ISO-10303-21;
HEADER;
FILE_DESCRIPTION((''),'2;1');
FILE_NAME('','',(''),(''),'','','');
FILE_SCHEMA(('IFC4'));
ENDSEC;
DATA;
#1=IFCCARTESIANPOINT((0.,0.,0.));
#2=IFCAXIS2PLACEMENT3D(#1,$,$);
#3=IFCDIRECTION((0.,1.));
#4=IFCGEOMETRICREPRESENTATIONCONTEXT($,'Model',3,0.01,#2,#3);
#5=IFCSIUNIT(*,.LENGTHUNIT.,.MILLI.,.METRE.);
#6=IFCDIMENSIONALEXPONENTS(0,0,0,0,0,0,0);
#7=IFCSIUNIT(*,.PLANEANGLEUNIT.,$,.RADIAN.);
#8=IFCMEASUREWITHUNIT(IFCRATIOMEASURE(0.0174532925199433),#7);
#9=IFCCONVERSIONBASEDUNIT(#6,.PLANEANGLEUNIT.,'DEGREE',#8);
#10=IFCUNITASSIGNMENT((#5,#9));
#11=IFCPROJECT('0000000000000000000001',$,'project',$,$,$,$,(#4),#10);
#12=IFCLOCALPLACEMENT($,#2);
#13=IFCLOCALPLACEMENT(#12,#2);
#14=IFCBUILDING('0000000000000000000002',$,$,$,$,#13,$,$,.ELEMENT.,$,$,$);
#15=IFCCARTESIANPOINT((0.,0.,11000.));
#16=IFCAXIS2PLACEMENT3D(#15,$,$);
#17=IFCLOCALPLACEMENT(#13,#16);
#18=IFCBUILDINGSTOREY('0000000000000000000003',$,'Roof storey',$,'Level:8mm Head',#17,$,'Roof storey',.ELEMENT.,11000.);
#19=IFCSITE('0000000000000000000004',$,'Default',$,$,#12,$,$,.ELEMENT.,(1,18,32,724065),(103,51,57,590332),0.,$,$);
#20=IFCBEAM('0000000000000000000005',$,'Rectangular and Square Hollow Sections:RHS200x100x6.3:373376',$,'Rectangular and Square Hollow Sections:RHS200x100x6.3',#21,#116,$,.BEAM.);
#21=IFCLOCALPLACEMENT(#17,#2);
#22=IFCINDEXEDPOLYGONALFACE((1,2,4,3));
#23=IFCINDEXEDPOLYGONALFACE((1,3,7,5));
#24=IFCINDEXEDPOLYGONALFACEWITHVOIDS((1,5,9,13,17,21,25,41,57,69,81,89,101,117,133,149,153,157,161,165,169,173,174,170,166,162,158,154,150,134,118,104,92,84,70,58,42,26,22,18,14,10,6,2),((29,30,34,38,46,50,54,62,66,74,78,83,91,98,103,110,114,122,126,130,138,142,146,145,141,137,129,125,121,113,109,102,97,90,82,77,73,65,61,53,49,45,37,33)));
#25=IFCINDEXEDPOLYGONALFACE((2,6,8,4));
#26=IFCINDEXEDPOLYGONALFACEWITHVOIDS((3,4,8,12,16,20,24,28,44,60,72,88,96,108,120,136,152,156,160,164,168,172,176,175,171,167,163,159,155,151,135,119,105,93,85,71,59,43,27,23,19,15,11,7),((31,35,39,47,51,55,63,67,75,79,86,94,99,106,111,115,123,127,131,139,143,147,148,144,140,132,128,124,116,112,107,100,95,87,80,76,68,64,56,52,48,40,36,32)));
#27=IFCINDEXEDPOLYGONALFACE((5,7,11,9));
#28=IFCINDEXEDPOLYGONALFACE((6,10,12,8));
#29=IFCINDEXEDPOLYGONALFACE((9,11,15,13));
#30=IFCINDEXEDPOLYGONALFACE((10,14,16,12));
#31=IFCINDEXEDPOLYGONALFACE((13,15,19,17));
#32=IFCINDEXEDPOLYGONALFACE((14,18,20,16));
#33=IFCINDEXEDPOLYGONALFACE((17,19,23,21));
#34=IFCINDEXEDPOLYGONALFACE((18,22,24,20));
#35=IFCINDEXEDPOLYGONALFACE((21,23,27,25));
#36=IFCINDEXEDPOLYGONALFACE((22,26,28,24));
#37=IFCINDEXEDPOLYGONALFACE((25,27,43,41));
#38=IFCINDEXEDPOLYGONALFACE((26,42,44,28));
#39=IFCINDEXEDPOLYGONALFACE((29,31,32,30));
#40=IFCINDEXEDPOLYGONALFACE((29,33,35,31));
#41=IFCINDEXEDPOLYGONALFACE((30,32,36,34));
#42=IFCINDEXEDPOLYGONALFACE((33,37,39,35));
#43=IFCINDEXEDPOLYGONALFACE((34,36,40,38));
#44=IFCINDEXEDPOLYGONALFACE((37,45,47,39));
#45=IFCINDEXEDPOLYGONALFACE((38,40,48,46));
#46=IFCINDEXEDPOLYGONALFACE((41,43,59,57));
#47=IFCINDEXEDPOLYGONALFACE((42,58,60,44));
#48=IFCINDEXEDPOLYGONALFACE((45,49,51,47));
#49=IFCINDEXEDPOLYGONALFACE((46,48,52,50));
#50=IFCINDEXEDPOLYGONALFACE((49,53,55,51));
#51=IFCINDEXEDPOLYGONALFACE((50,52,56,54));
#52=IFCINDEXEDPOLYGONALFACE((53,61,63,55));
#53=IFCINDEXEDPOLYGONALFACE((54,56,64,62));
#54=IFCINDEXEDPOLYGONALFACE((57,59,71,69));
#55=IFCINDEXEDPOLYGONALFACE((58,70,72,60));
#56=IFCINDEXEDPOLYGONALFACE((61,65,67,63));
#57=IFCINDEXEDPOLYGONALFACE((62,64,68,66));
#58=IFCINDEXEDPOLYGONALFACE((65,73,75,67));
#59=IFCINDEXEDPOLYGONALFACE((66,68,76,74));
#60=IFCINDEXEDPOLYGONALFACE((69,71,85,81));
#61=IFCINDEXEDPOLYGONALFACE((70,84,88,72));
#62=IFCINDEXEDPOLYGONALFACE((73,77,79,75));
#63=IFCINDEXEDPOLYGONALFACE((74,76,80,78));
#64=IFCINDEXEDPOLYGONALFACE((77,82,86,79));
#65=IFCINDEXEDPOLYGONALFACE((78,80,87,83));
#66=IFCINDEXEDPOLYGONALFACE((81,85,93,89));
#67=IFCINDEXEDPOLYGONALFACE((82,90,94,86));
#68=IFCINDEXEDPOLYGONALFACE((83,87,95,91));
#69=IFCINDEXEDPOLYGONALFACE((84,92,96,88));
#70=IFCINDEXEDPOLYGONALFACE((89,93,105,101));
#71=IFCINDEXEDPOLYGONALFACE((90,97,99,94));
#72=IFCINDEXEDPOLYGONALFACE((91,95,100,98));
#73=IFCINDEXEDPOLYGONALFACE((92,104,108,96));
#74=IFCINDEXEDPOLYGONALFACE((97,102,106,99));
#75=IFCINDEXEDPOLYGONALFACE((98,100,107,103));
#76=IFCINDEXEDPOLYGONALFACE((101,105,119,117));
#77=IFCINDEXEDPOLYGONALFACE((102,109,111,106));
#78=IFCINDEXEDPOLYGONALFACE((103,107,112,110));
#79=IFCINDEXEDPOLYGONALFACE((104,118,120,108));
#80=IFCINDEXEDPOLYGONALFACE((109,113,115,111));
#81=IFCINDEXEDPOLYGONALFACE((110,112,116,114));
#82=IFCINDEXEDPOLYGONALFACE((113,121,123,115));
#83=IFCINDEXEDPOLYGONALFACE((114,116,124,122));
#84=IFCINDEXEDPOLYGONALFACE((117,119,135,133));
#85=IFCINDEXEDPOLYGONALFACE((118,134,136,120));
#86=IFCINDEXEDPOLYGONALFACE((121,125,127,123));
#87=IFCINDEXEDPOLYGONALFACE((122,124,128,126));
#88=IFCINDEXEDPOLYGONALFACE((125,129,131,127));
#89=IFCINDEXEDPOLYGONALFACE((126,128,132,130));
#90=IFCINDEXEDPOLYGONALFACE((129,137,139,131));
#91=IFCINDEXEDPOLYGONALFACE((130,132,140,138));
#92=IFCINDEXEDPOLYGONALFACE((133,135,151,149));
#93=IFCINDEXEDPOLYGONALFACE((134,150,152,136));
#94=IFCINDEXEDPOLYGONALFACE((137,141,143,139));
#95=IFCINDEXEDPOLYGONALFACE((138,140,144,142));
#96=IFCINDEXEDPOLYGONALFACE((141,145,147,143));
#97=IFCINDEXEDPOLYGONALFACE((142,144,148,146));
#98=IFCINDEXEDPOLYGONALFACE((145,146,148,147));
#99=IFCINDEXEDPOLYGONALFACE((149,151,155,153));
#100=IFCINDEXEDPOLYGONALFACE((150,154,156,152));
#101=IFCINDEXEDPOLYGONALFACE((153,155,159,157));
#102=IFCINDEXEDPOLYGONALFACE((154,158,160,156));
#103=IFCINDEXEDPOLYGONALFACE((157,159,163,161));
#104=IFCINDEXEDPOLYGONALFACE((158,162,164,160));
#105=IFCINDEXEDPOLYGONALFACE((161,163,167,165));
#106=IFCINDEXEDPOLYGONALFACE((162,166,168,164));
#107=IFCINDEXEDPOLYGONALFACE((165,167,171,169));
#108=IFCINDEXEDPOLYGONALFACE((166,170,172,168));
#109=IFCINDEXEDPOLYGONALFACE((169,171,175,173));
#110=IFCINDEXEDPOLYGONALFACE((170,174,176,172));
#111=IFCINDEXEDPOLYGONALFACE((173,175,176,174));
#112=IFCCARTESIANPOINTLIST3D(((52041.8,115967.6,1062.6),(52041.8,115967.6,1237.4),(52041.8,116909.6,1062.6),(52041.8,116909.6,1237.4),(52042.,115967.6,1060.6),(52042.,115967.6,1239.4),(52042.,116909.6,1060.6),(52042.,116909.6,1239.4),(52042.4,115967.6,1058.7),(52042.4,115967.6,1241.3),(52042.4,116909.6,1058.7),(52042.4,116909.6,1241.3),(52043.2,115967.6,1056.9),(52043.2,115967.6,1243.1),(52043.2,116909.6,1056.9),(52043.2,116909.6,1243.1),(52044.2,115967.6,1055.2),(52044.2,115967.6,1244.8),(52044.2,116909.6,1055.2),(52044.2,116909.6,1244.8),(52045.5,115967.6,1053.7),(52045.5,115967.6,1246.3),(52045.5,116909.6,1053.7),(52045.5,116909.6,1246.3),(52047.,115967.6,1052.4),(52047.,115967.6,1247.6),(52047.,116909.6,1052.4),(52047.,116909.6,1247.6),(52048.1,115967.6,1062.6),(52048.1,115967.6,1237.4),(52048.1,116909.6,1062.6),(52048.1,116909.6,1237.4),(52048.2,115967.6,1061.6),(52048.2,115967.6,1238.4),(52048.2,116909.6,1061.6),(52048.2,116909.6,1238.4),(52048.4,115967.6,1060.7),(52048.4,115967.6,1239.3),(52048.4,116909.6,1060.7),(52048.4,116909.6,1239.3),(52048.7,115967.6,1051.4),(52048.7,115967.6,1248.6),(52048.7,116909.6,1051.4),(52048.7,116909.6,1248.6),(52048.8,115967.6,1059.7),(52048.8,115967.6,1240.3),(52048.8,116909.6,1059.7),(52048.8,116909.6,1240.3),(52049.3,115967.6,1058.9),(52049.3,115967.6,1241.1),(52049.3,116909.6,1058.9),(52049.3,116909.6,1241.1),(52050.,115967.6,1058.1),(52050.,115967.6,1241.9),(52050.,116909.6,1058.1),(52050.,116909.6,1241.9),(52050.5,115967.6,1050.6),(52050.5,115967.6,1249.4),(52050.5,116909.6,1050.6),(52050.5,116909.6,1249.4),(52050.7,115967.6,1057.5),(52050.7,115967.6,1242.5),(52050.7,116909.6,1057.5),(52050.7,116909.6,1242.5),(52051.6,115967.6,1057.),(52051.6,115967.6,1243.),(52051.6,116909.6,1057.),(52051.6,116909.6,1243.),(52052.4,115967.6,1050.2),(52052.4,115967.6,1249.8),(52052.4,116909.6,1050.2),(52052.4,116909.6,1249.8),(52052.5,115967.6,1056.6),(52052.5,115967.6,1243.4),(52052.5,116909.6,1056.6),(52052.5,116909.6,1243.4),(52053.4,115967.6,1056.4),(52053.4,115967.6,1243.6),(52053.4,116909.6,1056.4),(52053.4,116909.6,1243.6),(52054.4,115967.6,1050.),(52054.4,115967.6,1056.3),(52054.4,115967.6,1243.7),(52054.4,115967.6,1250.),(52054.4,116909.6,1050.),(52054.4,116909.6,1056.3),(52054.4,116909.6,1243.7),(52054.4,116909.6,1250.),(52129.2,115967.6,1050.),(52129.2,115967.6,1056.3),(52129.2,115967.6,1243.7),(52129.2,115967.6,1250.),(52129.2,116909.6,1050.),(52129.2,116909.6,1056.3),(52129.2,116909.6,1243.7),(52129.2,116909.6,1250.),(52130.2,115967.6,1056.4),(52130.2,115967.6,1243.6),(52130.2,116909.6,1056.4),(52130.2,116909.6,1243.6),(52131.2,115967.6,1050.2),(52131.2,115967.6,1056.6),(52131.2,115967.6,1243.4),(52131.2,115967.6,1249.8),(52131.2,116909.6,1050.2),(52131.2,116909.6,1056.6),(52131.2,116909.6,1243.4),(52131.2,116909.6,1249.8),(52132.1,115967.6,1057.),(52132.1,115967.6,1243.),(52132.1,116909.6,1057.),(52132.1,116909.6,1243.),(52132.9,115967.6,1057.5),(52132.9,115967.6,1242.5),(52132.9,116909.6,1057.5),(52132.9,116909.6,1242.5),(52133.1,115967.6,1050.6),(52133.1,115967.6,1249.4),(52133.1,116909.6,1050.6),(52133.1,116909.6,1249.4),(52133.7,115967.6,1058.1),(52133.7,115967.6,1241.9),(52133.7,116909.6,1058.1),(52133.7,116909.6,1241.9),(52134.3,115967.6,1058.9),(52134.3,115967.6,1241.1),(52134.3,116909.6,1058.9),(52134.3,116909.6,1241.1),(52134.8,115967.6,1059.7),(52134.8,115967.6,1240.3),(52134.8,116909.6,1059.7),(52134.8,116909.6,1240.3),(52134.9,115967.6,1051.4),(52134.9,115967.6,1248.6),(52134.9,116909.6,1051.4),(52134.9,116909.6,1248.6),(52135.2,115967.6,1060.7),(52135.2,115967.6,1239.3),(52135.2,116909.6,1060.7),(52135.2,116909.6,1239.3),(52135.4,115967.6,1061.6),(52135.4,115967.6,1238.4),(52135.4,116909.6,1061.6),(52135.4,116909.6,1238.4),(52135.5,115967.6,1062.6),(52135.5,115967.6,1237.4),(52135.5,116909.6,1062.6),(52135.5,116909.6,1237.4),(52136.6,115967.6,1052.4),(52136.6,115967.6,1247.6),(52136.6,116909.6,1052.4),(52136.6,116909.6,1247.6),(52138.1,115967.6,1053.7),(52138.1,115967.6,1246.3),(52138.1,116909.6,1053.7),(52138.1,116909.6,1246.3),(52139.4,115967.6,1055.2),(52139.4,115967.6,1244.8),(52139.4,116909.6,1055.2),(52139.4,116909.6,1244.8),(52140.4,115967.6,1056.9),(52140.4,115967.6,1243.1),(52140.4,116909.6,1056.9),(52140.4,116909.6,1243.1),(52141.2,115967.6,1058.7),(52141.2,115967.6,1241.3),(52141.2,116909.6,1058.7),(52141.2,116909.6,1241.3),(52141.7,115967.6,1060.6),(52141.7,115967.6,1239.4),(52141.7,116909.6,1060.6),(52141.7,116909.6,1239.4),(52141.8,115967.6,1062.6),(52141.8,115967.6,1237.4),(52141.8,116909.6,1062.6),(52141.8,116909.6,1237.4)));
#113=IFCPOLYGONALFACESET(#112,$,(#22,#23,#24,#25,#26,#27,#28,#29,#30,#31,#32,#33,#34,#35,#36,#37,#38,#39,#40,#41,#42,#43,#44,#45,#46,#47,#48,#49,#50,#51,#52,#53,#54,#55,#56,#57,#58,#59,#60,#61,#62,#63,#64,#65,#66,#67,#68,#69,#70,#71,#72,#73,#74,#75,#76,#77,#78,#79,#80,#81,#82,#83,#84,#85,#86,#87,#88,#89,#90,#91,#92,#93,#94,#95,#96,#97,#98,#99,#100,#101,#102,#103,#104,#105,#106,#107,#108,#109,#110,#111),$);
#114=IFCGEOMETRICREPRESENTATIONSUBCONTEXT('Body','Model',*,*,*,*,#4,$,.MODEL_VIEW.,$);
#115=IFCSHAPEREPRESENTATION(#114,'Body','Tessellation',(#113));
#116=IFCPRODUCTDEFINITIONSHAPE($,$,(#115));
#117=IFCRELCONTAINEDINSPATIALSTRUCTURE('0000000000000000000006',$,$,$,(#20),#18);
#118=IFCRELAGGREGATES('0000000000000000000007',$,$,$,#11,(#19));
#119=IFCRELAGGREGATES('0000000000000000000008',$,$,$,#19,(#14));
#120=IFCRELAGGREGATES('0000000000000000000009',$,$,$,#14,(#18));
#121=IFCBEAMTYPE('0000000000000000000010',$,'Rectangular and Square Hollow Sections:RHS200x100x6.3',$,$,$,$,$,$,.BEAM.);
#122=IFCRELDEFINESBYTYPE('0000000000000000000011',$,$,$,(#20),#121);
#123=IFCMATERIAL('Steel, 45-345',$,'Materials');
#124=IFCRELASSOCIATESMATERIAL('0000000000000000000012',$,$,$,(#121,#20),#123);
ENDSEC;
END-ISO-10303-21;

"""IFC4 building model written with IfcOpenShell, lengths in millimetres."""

from ifc_helpers import new_model, entity, si_unit, converted_unit, direction, frame, origin, place, context, subcontext, project, spatial, indexed_curve, outline, extrude, source, transform, mapped, material, type_object, type_shapes, element, save


model = new_model("IFC4")

# Units and contexts
model_context = context("Model", 3, precision=0.01, world=origin(), true_north=direction((0.0, 1.0)))
body_context = subcontext(model_context, "Body", "Model", "MODEL_VIEW")
ifc_project = project(units=[si_unit("LENGTHUNIT", "METRE", prefix="MILLI"), converted_unit("PLANEANGLEUNIT", "DEGREE", entity("IfcRatioMeasure", 0.0174532925199433), si_unit("PLANEANGLEUNIT", "RADIAN"), dimensions=[0, 0, 0, 0, 0, 0, 0])], contexts=[model_context])

# Site, building, storey
site_placement = place(None, origin())
site = spatial("IfcSite", under=ifc_project, at=site_placement, Name="Default", CompositionType="ELEMENT", RefLatitude=(1, 18, 32, 724065), RefLongitude=(103, 51, 57, 590332), RefElevation=0.0)
building_placement = place(site_placement, origin())
building = spatial("IfcBuilding", under=site, at=building_placement, CompositionType="ELEMENT")
storey_placement = place(building_placement, frame((0.0, 0.0, 11000.0)))
storey = spatial("IfcBuildingStorey", under=building, at=storey_placement, Name="Roof storey", ObjectType="Level:8mm Head", LongName="Roof storey", CompositionType="ELEMENT", Elevation=11000.0)

# Shared definitions
ifc_material = material(Name="Steel, 45-345", Category="Materials")

# Beam
beam_type_1 = type_object("IfcBeamType", Name="Rectangular and Square Hollow Sections:RHS200x100x6.3", PredefinedType="BEAM", material=ifc_material)
shared_shape_1 = source(origin(), body_context, "Body", "SweptSolid", [
    extrude(outline(indexed_curve([(-50.0, -87.4), (-49.8, -89.4), (-49.4, -91.3), (-48.6, -93.1), (-47.6, -94.8), (-46.3, -96.3), (-44.8, -97.6), (-43.1, -98.6), (-41.3, -99.4), (-39.4, -99.8), (-37.4, -100.0), (37.4, -100.0), (39.4, -99.8), (41.3, -99.4), (43.1, -98.6), (44.8, -97.6), (46.3, -96.3), (47.6, -94.8), (48.6, -93.1), (49.4, -91.3), (49.8, -89.4), (50.0, -87.4), (50.0, 87.4), (49.8, 89.4), (49.4, 91.3), (48.6, 93.1), (47.6, 94.8), (46.3, 96.3), (44.8, 97.6), (43.1, 98.6), (41.3, 99.4), (39.4, 99.8), (37.4, 100.0), (-37.4, 100.0), (-39.4, 99.8), (-41.3, 99.4), (-43.1, 98.6), (-44.8, 97.6), (-46.3, 96.3), (-47.6, 94.8), (-48.6, 93.1), (-49.4, 91.3), (-49.8, 89.4), (-50.0, 87.4), (-50.0, -87.4)], self_intersect=False), holes=[indexed_curve([(37.4, -93.7), (-37.4, -93.7), (-38.4, -93.6), (-39.3, -93.4), (-40.3, -93.0), (-41.1, -92.5), (-41.9, -91.9), (-42.5, -91.1), (-43.0, -90.3), (-43.4, -89.3), (-43.6, -88.4), (-43.7, -87.4), (-43.7, 87.4), (-43.6, 88.4), (-43.4, 89.3), (-43.0, 90.3), (-42.5, 91.1), (-41.9, 91.9), (-41.1, 92.5), (-40.3, 93.0), (-39.3, 93.4), (-38.4, 93.6), (-37.4, 93.7), (37.4, 93.7), (38.4, 93.6), (39.3, 93.4), (40.3, 93.0), (41.1, 92.5), (41.9, 91.9), (42.5, 91.1), (43.0, 90.3), (43.4, 89.3), (43.6, 88.4), (43.7, 87.4), (43.7, -87.4), (43.6, -88.4), (43.4, -89.3), (43.0, -90.3), (42.5, -91.1), (41.9, -91.9), (41.1, -92.5), (40.3, -93.0), (39.3, -93.4), (38.4, -93.6), (37.4, -93.7)], self_intersect=False)]), frame((-412.0, 0.0, 0.0), z_axis=(1.0, 0.0, 0.0), x_axis=(0.0, -1.0, 0.0)), (0.0, 0.0, 1.0), 942.0),
])
type_shapes(beam_type_1, [shared_shape_1])
beam_1_placement = place(storey_placement, frame((52091.8, 116379.6, 1150.0), z_axis=(0.0, 0.0, 1.0), x_axis=(0.0, 1.0, 0.0)))
element("IfcBeam", 1, at=beam_1_placement, inside=storey, type_object=beam_type_1, material=ifc_material, Name="Rectangular and Square Hollow Sections:RHS200x100x6.3:373376", ObjectType="Rectangular and Square Hollow Sections:RHS200x100x6.3", PredefinedType="BEAM", context=body_context, shape_type="MappedRepresentation", body=[
    mapped(shared_shape_1, transform((0.0, 0.0, 0.0), scale=1.0)),
])

save(model, "model.ifc")
